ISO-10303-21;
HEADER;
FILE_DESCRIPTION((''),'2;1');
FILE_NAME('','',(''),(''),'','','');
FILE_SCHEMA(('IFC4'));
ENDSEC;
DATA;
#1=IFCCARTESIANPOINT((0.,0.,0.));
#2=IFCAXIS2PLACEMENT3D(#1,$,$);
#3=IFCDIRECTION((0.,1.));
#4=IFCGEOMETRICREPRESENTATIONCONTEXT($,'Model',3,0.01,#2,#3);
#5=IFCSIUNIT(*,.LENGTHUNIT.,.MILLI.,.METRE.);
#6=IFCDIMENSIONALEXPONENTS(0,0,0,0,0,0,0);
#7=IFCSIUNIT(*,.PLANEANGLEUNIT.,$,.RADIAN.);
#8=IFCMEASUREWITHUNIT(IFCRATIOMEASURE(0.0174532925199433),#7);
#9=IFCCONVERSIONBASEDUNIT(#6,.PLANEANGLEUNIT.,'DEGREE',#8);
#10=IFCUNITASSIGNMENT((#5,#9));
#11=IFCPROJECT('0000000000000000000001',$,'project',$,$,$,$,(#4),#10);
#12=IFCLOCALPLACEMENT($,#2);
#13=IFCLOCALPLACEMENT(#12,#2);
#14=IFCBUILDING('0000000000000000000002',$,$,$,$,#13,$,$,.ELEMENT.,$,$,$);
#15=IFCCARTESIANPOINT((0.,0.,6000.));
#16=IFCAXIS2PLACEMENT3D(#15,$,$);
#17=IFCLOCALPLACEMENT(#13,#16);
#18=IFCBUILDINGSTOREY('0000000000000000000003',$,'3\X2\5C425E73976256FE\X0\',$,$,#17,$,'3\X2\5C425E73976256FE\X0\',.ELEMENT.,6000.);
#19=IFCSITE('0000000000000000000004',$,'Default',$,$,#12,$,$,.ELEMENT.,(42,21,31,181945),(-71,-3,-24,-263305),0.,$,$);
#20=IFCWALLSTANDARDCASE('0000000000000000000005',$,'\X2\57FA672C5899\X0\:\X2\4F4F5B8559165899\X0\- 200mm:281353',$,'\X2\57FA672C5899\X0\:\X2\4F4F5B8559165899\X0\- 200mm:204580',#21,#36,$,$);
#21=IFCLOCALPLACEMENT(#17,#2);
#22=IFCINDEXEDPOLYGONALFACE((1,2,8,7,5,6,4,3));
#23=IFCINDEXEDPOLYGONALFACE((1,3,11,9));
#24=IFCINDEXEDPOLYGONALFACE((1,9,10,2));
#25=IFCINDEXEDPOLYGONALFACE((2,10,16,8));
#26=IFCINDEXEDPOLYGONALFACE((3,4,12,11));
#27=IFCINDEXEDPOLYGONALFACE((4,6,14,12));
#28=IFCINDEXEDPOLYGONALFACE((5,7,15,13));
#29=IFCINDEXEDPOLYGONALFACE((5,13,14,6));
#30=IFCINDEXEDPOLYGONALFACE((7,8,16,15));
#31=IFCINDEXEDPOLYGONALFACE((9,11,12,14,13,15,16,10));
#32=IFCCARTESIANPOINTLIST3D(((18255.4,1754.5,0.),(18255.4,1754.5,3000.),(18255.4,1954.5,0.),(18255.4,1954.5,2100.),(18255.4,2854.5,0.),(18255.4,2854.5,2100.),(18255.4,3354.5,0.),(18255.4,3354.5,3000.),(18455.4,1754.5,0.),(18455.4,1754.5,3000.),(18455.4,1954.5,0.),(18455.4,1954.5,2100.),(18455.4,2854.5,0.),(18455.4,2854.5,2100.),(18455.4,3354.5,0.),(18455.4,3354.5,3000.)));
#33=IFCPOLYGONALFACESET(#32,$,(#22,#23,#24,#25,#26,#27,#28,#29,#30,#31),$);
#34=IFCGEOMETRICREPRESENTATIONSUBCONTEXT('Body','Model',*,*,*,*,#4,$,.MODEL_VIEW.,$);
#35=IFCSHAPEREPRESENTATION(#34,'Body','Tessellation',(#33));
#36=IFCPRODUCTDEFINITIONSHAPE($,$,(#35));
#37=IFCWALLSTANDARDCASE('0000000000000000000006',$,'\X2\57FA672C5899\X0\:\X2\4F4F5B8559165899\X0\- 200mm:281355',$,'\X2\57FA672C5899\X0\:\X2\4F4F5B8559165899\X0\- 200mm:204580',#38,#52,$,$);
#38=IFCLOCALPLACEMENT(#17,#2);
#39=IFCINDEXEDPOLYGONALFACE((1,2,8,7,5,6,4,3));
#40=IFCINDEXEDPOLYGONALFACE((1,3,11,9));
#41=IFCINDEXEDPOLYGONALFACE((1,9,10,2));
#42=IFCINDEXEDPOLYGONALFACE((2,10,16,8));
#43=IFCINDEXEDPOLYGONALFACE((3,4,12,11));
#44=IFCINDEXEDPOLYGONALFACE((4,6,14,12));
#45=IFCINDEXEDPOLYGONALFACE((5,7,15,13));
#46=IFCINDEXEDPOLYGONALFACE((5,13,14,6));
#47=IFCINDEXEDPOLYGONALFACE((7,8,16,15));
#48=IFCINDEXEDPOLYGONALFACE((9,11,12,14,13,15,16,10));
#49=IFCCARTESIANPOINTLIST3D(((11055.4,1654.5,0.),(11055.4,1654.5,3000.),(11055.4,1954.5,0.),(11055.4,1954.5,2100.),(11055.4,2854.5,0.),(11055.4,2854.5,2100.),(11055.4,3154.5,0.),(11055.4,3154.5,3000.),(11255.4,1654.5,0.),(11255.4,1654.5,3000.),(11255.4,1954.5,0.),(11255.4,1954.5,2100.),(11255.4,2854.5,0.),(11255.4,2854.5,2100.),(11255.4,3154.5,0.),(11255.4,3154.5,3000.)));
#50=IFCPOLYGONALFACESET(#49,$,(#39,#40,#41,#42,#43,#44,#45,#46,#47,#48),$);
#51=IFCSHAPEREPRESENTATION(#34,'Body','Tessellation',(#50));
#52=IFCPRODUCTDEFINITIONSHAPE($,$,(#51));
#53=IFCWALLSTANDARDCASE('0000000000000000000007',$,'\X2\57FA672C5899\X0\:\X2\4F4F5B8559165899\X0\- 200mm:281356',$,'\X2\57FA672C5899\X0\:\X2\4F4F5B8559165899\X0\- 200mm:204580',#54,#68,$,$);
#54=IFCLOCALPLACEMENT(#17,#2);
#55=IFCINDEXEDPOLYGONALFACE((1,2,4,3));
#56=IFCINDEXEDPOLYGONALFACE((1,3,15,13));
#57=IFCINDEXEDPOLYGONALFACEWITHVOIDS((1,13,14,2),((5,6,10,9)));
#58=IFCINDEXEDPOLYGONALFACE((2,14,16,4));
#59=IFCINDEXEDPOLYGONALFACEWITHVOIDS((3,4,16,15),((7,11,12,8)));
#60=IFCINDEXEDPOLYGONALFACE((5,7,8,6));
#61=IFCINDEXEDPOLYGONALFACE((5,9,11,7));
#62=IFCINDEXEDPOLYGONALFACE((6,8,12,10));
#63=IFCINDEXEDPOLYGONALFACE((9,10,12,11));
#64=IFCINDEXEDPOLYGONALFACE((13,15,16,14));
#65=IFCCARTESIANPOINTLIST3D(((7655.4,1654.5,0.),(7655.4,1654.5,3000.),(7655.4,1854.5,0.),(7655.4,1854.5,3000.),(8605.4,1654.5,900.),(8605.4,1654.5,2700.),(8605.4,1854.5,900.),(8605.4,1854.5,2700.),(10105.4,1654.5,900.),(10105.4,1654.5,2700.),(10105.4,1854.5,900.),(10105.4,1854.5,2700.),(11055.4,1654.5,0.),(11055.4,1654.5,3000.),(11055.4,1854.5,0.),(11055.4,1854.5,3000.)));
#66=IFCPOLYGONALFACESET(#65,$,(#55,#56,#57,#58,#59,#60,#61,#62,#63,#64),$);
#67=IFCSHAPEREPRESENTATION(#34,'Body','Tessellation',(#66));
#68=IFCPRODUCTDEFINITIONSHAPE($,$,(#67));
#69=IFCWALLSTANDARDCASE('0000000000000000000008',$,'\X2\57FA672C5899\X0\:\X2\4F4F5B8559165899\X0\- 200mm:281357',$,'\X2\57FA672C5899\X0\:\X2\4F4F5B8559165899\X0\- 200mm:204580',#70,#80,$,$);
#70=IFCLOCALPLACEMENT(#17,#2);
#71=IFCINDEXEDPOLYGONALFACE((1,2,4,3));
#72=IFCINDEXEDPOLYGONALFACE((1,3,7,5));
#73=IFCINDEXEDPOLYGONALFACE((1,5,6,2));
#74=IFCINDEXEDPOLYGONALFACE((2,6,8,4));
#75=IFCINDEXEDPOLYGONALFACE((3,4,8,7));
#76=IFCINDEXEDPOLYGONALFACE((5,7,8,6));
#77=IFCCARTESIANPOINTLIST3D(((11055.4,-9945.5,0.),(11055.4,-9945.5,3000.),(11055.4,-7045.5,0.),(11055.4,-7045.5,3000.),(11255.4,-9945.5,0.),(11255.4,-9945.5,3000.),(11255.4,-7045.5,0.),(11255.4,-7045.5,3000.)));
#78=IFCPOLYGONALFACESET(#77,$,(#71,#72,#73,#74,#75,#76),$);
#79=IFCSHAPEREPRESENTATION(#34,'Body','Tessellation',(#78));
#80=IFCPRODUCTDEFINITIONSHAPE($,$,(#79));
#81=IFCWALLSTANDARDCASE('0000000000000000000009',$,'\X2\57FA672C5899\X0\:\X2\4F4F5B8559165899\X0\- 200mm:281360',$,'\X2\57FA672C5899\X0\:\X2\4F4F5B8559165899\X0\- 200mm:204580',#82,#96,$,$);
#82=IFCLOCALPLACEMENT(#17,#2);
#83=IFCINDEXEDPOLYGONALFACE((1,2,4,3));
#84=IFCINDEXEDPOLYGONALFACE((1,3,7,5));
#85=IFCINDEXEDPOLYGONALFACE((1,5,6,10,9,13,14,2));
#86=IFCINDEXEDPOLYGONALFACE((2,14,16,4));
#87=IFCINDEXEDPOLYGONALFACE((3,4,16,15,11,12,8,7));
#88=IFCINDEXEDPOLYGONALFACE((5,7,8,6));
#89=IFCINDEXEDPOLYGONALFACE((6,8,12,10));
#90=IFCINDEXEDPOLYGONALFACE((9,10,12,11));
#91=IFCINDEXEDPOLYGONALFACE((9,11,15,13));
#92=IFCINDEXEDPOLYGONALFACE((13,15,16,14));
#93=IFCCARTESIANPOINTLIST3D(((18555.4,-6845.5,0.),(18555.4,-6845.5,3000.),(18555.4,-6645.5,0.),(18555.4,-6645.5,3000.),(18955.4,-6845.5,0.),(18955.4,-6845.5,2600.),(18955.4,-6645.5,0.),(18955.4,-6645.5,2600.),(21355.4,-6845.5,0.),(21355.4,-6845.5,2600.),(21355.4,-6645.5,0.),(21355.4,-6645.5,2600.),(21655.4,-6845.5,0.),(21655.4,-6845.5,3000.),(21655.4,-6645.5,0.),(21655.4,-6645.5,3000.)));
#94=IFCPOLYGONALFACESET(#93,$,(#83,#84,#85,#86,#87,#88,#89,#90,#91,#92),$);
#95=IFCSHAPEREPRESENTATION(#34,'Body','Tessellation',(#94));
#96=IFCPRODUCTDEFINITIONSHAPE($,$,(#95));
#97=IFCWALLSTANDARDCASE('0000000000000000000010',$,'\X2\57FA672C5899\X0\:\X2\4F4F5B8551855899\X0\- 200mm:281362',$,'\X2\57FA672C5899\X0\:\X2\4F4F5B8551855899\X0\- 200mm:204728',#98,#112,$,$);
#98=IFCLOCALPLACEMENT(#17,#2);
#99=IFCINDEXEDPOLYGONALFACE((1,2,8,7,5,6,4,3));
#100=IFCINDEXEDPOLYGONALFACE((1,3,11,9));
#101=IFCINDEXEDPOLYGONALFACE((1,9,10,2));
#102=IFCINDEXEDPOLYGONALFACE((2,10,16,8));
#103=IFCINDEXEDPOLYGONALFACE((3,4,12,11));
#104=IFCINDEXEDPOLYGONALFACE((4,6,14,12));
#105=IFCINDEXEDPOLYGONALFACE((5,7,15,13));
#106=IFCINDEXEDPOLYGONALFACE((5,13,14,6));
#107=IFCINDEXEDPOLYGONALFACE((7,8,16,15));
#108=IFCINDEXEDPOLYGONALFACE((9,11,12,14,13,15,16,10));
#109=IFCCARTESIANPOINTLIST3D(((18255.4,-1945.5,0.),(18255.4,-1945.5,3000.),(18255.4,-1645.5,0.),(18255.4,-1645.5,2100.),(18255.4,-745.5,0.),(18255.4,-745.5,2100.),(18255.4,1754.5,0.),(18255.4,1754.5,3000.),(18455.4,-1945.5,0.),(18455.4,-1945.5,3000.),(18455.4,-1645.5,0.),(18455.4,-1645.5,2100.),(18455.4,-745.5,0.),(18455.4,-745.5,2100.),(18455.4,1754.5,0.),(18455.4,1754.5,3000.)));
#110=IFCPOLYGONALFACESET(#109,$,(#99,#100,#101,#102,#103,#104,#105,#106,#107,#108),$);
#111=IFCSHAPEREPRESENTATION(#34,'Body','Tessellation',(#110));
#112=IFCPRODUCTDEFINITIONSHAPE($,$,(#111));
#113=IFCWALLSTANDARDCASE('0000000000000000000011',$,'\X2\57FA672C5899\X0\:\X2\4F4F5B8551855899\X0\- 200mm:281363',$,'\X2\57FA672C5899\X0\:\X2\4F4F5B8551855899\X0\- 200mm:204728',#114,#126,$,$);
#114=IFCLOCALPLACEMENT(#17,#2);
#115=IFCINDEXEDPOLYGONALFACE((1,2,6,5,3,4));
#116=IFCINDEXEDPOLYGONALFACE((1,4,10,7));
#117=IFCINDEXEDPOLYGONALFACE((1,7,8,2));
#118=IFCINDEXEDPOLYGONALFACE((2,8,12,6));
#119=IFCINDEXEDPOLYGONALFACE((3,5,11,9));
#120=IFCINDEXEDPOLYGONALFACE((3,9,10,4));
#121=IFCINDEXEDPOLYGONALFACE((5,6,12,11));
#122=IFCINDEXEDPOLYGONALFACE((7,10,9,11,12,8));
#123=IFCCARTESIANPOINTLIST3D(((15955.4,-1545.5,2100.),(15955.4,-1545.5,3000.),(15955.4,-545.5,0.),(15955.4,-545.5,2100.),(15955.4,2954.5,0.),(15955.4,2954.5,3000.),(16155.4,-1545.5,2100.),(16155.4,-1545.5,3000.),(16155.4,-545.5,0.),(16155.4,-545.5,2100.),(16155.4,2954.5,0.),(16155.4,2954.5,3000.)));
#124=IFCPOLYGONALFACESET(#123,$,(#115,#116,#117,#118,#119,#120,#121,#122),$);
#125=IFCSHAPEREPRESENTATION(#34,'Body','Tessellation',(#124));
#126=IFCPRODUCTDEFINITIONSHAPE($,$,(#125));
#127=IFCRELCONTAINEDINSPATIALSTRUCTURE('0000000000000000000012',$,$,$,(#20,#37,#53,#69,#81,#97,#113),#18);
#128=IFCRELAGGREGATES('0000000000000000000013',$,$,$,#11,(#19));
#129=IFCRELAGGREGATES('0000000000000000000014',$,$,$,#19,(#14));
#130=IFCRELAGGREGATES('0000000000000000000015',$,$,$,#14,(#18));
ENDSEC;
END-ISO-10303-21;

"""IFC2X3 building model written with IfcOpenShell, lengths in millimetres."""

from ifc_helpers import new_model, entity, si_unit, converted_unit, direction, frame, frame_2d, origin, place, context, subcontext, project, spatial, polyline, rectangle, extrude, clip, bounded_halfspace, element, save


model = new_model("IFC2X3")

# Units and contexts
model_context = context("Model", 3, precision=0.01, world=origin(), true_north=direction((0.0, 1.0)))
body_context = subcontext(model_context, "Body", "Model", "MODEL_VIEW")
ifc_project = project(units=[si_unit("LENGTHUNIT", "METRE", prefix="MILLI"), converted_unit("PLANEANGLEUNIT", "DEGREE", entity("IfcRatioMeasure", 0.0174532925199433), si_unit("PLANEANGLEUNIT", "RADIAN"), dimensions=[0, 0, 0, 0, 0, 0, 0])], contexts=[model_context])

# Site, building, storey
site_placement = place(None, origin())
site = spatial("IfcSite", under=ifc_project, at=site_placement, Name="Default", CompositionType="ELEMENT", RefLatitude=(42, 21, 31, 181945), RefLongitude=(-71, -3, -24, -263305), RefElevation=0.0)
building_placement = place(site_placement, origin())
building = spatial("IfcBuilding", under=site, at=building_placement, CompositionType="ELEMENT")
storey_placement = place(building_placement, frame((0.0, 0.0, 6000.0)))
storey = spatial("IfcBuildingStorey", under=building, at=storey_placement, Name="3层平面图", LongName="3层平面图", CompositionType="ELEMENT", Elevation=6000.0)

# Walls, openings
wall_1_placement = place(storey_placement, frame((18355.4, 1754.5, 0.0), z_axis=(0.0, 0.0, 1.0), x_axis=(0.0, 1.0, 0.0)))
wall_1 = element("IfcWallStandardCase", 1, at=wall_1_placement, inside=storey, Name="基本墙:住宅外墙- 200mm:281353", ObjectType="基本墙:住宅外墙- 200mm:204580", context=body_context, shape_type="SweptSolid", body=[
    extrude(rectangle(XDim=1600.0, YDim=200.0, at=frame_2d((800.0, 0.0), x_axis=(-1.0, 0.0))), origin(), (0.0, 0.0, 1.0), 3000.0),
])
opening_1_placement = place(wall_1_placement, frame((1100.0, 100.0, 0.0)))
element("IfcOpeningElement", 2, at=opening_1_placement, cuts=wall_1, ObjectType="Opening", context=body_context, shape_type="SweptSolid", body=[
    extrude(rectangle(XDim=2100.0, YDim=900.0, at=frame_2d((1050.0, 450.0), x_axis=(1.0, 0.0))), frame((0.0, 0.0, 0.0), z_axis=(0.0, -1.0, 0.0), x_axis=(0.0, 0.0, 1.0)), (0.0, 0.0, 1.0), 200.0),
])
opening_2_placement = place(wall_1_placement, origin())
element("IfcOpeningElement", 3, at=opening_2_placement, cuts=wall_1, ObjectType="Opening", context=body_context, shape_type="SweptSolid", body=[
    extrude(rectangle(XDim=2100.0, YDim=900.0, at=frame_2d((0.0, 0.0), x_axis=(1.0, 0.0))), frame((650.0, -1424.0, 4050.0), z_axis=(0.0, 1.0, 0.0), x_axis=(0.0, 0.0, 1.0)), (0.0, 0.0, 1.0), 3048.0),
])
wall_2_placement = place(storey_placement, frame((11155.4, 3154.5, 0.0), z_axis=(0.0, 0.0, 1.0), x_axis=(0.0, -1.0, 0.0)))
wall_2 = element("IfcWallStandardCase", 4, at=wall_2_placement, inside=storey, Name="基本墙:住宅外墙- 200mm:281355", ObjectType="基本墙:住宅外墙- 200mm:204580", context=body_context, shape_type="SweptSolid", body=[
    extrude(rectangle(XDim=1500.0, YDim=200.0, at=frame_2d((750.0, 0.0), x_axis=(-1.0, 0.0))), origin(), (0.0, 0.0, 1.0), 3000.0),
])
opening_3_placement = place(wall_2_placement, frame((1200.0, 100.0, 0.0)))
element("IfcOpeningElement", 5, at=opening_3_placement, cuts=wall_2, ObjectType="Opening", context=body_context, shape_type="SweptSolid", body=[
    extrude(rectangle(XDim=2100.0, YDim=900.0, at=frame_2d((1050.0, 450.0), x_axis=(1.0, 0.0))), frame((0.0, 0.0, 0.0), z_axis=(0.0, -1.0, 0.0), x_axis=(0.0, 0.0, 1.0)), (0.0, 0.0, 1.0), 200.0),
])
opening_4_placement = place(wall_2_placement, origin())
element("IfcOpeningElement", 6, at=opening_4_placement, cuts=wall_2, ObjectType="Opening", context=body_context, shape_type="SweptSolid", body=[
    extrude(rectangle(XDim=2100.0, YDim=900.0, at=frame_2d((0.0, 0.0), x_axis=(0.0, 1.0))), frame((750.0, -1424.0, 4050.0), z_axis=(0.0, 1.0, 0.0), x_axis=(-1.0, 0.0, 0.0)), (0.0, 0.0, 1.0), 3048.0),
])

# Wall, opening
wall_3_placement = place(storey_placement, frame((11055.4, 1754.5, 0.0), z_axis=(0.0, 0.0, 1.0), x_axis=(-1.0, 0.0, 0.0)))
wall_3 = element("IfcWallStandardCase", 7, at=wall_3_placement, inside=storey, Name="基本墙:住宅外墙- 200mm:281356", ObjectType="基本墙:住宅外墙- 200mm:204580", context=body_context, shape_type="SweptSolid", body=[
    extrude(rectangle(XDim=3400.0, YDim=200.0, at=frame_2d((1700.0, 0.0), x_axis=(-1.0, 0.0))), origin(), (0.0, 0.0, 1.0), 3000.0),
])
opening_5_placement = place(wall_3_placement, frame((950.0, -100.0, 900.0)))
element("IfcOpeningElement", 8, at=opening_5_placement, cuts=wall_3, ObjectType="Opening", context=body_context, shape_type="SweptSolid", body=[
    extrude(rectangle(XDim=1800.0, YDim=1500.0, at=frame_2d((900.0, 750.0), x_axis=(1.0, 0.0))), frame((0.0, 0.0, 0.0), z_axis=(0.0, 1.0, 0.0), x_axis=(0.0, 0.0, 1.0)), (0.0, 0.0, 1.0), 200.0),
])

# Wall
wall_4_placement = place(storey_placement, frame((11155.4, -7045.5, 0.0), z_axis=(0.0, 0.0, 1.0), x_axis=(0.0, -1.0, 0.0)))
element("IfcWallStandardCase", 9, at=wall_4_placement, inside=storey, Name="基本墙:住宅外墙- 200mm:281357", ObjectType="基本墙:住宅外墙- 200mm:204580", context=body_context, shape_type="Clipping", body=[
    clip(clip(extrude(rectangle(XDim=2900.0, YDim=200.0, at=frame_2d((1450.0, 0.0), x_axis=(-1.0, 0.0))), origin(), (0.0, 0.0, 1.0), 3000.0), bounded_halfspace(frame((0.0, -100.0, 0.0), z_axis=(1.0, 0.0, 0.0), x_axis=(0.0, 0.0, -1.0)), True, frame((0.0, -100.0, 0.0), z_axis=(1.0, 0.0, 0.0), x_axis=(0.0, 0.0, -1.0)), polyline([(0.0, 0.0), (0.0, 200.0), (-3000.0, 200.0), (-3000.0, 0.0), (0.0, 0.0)]))), bounded_halfspace(frame((2900.0, -100.0, 3000.0), z_axis=(-1.0, 0.0, 0.0), x_axis=(0.0, 0.0, -1.0)), True, frame((2900.0, -100.0, 3000.0), z_axis=(-1.0, 0.0, 0.0), x_axis=(0.0, 0.0, -1.0)), polyline([(0.0, 0.0), (0.0, -200.0), (3000.0, -200.0), (3000.0, 0.0), (0.0, 0.0)]))),
])

# Walls, openings
wall_5_placement = place(storey_placement, frame((18555.4, -6745.5, 0.0)))
wall_5 = element("IfcWallStandardCase", 10, at=wall_5_placement, inside=storey, Name="基本墙:住宅外墙- 200mm:281360", ObjectType="基本墙:住宅外墙- 200mm:204580", context=body_context, shape_type="Clipping", body=[
    clip(clip(extrude(rectangle(XDim=3100.0, YDim=200.0, at=frame_2d((1550.0, 0.0), x_axis=(-1.0, 0.0))), origin(), (0.0, 0.0, 1.0), 3000.0), bounded_halfspace(frame((0.0, -100.0, 0.0), z_axis=(-1.0, 0.0, 0.0), x_axis=(0.0, 0.0, -1.0)), False, frame((0.0, -100.0, 0.0), z_axis=(-1.0, 0.0, 0.0), x_axis=(0.0, 0.0, -1.0)), polyline([(0.0, 0.0), (-3000.0, 0.0), (-3000.0, -200.0), (0.0, -200.0), (0.0, 0.0)]))), bounded_halfspace(frame((3100.0, -100.0, 3000.0), z_axis=(1.0, 0.0, 0.0), x_axis=(0.0, 0.0, -1.0)), False, frame((3100.0, -100.0, 3000.0), z_axis=(1.0, 0.0, 0.0), x_axis=(0.0, 0.0, -1.0)), polyline([(0.0, 0.0), (3000.0, 0.0), (3000.0, 200.0), (0.0, 200.0), (0.0, 0.0)]))),
])
opening_6_placement = place(wall_5_placement, frame((2800.0, 100.0, 0.0)))
element("IfcOpeningElement", 11, at=opening_6_placement, cuts=wall_5, ObjectType="Opening", context=body_context, shape_type="SweptSolid", body=[
    extrude(rectangle(XDim=2600.0, YDim=2400.0, at=frame_2d((1300.0, 1200.0), x_axis=(1.0, 0.0))), frame((0.0, 0.0, 0.0), z_axis=(0.0, -1.0, 0.0), x_axis=(0.0, 0.0, 1.0)), (0.0, 0.0, 1.0), 200.0),
])
wall_6_placement = place(storey_placement, frame((18355.4, -1945.5, 0.0), z_axis=(0.0, 0.0, 1.0), x_axis=(0.0, 1.0, 0.0)))
wall_6 = element("IfcWallStandardCase", 12, at=wall_6_placement, inside=storey, Name="基本墙:住宅内墙- 200mm:281362", ObjectType="基本墙:住宅内墙- 200mm:204728", context=body_context, shape_type="SweptSolid", body=[
    extrude(rectangle(XDim=3700.0, YDim=200.0, at=frame_2d((1850.0, 0.0), x_axis=(-1.0, 0.0))), origin(), (0.0, 0.0, 1.0), 3000.0),
])
opening_7_placement = place(wall_6_placement, frame((1200.0, 100.0, 0.0)))
element("IfcOpeningElement", 13, at=opening_7_placement, cuts=wall_6, ObjectType="Opening", context=body_context, shape_type="SweptSolid", body=[
    extrude(rectangle(XDim=2100.0, YDim=900.0, at=frame_2d((1050.0, 450.0), x_axis=(1.0, 0.0))), frame((0.0, 0.0, 0.0), z_axis=(0.0, -1.0, 0.0), x_axis=(0.0, 0.0, 1.0)), (0.0, 0.0, 1.0), 200.0),
])
wall_7_placement = place(storey_placement, frame((16055.4, 2954.5, 0.0), z_axis=(0.0, 0.0, 1.0), x_axis=(0.0, -1.0, 0.0)))
wall_7 = element("IfcWallStandardCase", 14, at=wall_7_placement, inside=storey, Name="基本墙:住宅内墙- 200mm:281363", ObjectType="基本墙:住宅内墙- 200mm:204728", context=body_context, shape_type="Clipping", body=[
    clip(clip(extrude(rectangle(XDim=4500.0, YDim=200.0, at=frame_2d((2250.0, 0.0), x_axis=(-1.0, 0.0))), origin(), (0.0, 0.0, 1.0), 3000.0), bounded_halfspace(frame((4500.0, -100.0, 3000.0), z_axis=(1.0, 0.0, 0.0), x_axis=(0.0, 0.0, -1.0)), False, frame((4500.0, -100.0, 3000.0), z_axis=(1.0, 0.0, 0.0), x_axis=(0.0, 0.0, -1.0)), polyline([(0.0, 0.0), (900.0, 0.0), (900.0, 200.0), (0.0, 200.0), (0.0, 0.0)]))), bounded_halfspace(frame((0.0, -100.0, 0.0), z_axis=(-1.0, 0.0, 0.0), x_axis=(0.0, 0.0, -1.0)), False, frame((0.0, -100.0, 0.0), z_axis=(-1.0, 0.0, 0.0), x_axis=(0.0, 0.0, -1.0)), polyline([(0.0, 0.0), (-3000.0, 0.0), (-3000.0, -200.0), (0.0, -200.0), (0.0, 0.0)]))),
])
opening_8_placement = place(wall_7_placement, frame((4500.0, 100.0, 0.0)))
element("IfcOpeningElement", 15, at=opening_8_placement, cuts=wall_7, ObjectType="Opening", context=body_context, shape_type="SweptSolid", body=[
    extrude(rectangle(XDim=2100.0, YDim=1000.0, at=frame_2d((1050.0, 500.0), x_axis=(1.0, 0.0))), frame((0.0, 0.0, 0.0), z_axis=(0.0, -1.0, 0.0), x_axis=(0.0, 0.0, 1.0)), (0.0, 0.0, 1.0), 200.0),
])

save(model, "model.ifc")
